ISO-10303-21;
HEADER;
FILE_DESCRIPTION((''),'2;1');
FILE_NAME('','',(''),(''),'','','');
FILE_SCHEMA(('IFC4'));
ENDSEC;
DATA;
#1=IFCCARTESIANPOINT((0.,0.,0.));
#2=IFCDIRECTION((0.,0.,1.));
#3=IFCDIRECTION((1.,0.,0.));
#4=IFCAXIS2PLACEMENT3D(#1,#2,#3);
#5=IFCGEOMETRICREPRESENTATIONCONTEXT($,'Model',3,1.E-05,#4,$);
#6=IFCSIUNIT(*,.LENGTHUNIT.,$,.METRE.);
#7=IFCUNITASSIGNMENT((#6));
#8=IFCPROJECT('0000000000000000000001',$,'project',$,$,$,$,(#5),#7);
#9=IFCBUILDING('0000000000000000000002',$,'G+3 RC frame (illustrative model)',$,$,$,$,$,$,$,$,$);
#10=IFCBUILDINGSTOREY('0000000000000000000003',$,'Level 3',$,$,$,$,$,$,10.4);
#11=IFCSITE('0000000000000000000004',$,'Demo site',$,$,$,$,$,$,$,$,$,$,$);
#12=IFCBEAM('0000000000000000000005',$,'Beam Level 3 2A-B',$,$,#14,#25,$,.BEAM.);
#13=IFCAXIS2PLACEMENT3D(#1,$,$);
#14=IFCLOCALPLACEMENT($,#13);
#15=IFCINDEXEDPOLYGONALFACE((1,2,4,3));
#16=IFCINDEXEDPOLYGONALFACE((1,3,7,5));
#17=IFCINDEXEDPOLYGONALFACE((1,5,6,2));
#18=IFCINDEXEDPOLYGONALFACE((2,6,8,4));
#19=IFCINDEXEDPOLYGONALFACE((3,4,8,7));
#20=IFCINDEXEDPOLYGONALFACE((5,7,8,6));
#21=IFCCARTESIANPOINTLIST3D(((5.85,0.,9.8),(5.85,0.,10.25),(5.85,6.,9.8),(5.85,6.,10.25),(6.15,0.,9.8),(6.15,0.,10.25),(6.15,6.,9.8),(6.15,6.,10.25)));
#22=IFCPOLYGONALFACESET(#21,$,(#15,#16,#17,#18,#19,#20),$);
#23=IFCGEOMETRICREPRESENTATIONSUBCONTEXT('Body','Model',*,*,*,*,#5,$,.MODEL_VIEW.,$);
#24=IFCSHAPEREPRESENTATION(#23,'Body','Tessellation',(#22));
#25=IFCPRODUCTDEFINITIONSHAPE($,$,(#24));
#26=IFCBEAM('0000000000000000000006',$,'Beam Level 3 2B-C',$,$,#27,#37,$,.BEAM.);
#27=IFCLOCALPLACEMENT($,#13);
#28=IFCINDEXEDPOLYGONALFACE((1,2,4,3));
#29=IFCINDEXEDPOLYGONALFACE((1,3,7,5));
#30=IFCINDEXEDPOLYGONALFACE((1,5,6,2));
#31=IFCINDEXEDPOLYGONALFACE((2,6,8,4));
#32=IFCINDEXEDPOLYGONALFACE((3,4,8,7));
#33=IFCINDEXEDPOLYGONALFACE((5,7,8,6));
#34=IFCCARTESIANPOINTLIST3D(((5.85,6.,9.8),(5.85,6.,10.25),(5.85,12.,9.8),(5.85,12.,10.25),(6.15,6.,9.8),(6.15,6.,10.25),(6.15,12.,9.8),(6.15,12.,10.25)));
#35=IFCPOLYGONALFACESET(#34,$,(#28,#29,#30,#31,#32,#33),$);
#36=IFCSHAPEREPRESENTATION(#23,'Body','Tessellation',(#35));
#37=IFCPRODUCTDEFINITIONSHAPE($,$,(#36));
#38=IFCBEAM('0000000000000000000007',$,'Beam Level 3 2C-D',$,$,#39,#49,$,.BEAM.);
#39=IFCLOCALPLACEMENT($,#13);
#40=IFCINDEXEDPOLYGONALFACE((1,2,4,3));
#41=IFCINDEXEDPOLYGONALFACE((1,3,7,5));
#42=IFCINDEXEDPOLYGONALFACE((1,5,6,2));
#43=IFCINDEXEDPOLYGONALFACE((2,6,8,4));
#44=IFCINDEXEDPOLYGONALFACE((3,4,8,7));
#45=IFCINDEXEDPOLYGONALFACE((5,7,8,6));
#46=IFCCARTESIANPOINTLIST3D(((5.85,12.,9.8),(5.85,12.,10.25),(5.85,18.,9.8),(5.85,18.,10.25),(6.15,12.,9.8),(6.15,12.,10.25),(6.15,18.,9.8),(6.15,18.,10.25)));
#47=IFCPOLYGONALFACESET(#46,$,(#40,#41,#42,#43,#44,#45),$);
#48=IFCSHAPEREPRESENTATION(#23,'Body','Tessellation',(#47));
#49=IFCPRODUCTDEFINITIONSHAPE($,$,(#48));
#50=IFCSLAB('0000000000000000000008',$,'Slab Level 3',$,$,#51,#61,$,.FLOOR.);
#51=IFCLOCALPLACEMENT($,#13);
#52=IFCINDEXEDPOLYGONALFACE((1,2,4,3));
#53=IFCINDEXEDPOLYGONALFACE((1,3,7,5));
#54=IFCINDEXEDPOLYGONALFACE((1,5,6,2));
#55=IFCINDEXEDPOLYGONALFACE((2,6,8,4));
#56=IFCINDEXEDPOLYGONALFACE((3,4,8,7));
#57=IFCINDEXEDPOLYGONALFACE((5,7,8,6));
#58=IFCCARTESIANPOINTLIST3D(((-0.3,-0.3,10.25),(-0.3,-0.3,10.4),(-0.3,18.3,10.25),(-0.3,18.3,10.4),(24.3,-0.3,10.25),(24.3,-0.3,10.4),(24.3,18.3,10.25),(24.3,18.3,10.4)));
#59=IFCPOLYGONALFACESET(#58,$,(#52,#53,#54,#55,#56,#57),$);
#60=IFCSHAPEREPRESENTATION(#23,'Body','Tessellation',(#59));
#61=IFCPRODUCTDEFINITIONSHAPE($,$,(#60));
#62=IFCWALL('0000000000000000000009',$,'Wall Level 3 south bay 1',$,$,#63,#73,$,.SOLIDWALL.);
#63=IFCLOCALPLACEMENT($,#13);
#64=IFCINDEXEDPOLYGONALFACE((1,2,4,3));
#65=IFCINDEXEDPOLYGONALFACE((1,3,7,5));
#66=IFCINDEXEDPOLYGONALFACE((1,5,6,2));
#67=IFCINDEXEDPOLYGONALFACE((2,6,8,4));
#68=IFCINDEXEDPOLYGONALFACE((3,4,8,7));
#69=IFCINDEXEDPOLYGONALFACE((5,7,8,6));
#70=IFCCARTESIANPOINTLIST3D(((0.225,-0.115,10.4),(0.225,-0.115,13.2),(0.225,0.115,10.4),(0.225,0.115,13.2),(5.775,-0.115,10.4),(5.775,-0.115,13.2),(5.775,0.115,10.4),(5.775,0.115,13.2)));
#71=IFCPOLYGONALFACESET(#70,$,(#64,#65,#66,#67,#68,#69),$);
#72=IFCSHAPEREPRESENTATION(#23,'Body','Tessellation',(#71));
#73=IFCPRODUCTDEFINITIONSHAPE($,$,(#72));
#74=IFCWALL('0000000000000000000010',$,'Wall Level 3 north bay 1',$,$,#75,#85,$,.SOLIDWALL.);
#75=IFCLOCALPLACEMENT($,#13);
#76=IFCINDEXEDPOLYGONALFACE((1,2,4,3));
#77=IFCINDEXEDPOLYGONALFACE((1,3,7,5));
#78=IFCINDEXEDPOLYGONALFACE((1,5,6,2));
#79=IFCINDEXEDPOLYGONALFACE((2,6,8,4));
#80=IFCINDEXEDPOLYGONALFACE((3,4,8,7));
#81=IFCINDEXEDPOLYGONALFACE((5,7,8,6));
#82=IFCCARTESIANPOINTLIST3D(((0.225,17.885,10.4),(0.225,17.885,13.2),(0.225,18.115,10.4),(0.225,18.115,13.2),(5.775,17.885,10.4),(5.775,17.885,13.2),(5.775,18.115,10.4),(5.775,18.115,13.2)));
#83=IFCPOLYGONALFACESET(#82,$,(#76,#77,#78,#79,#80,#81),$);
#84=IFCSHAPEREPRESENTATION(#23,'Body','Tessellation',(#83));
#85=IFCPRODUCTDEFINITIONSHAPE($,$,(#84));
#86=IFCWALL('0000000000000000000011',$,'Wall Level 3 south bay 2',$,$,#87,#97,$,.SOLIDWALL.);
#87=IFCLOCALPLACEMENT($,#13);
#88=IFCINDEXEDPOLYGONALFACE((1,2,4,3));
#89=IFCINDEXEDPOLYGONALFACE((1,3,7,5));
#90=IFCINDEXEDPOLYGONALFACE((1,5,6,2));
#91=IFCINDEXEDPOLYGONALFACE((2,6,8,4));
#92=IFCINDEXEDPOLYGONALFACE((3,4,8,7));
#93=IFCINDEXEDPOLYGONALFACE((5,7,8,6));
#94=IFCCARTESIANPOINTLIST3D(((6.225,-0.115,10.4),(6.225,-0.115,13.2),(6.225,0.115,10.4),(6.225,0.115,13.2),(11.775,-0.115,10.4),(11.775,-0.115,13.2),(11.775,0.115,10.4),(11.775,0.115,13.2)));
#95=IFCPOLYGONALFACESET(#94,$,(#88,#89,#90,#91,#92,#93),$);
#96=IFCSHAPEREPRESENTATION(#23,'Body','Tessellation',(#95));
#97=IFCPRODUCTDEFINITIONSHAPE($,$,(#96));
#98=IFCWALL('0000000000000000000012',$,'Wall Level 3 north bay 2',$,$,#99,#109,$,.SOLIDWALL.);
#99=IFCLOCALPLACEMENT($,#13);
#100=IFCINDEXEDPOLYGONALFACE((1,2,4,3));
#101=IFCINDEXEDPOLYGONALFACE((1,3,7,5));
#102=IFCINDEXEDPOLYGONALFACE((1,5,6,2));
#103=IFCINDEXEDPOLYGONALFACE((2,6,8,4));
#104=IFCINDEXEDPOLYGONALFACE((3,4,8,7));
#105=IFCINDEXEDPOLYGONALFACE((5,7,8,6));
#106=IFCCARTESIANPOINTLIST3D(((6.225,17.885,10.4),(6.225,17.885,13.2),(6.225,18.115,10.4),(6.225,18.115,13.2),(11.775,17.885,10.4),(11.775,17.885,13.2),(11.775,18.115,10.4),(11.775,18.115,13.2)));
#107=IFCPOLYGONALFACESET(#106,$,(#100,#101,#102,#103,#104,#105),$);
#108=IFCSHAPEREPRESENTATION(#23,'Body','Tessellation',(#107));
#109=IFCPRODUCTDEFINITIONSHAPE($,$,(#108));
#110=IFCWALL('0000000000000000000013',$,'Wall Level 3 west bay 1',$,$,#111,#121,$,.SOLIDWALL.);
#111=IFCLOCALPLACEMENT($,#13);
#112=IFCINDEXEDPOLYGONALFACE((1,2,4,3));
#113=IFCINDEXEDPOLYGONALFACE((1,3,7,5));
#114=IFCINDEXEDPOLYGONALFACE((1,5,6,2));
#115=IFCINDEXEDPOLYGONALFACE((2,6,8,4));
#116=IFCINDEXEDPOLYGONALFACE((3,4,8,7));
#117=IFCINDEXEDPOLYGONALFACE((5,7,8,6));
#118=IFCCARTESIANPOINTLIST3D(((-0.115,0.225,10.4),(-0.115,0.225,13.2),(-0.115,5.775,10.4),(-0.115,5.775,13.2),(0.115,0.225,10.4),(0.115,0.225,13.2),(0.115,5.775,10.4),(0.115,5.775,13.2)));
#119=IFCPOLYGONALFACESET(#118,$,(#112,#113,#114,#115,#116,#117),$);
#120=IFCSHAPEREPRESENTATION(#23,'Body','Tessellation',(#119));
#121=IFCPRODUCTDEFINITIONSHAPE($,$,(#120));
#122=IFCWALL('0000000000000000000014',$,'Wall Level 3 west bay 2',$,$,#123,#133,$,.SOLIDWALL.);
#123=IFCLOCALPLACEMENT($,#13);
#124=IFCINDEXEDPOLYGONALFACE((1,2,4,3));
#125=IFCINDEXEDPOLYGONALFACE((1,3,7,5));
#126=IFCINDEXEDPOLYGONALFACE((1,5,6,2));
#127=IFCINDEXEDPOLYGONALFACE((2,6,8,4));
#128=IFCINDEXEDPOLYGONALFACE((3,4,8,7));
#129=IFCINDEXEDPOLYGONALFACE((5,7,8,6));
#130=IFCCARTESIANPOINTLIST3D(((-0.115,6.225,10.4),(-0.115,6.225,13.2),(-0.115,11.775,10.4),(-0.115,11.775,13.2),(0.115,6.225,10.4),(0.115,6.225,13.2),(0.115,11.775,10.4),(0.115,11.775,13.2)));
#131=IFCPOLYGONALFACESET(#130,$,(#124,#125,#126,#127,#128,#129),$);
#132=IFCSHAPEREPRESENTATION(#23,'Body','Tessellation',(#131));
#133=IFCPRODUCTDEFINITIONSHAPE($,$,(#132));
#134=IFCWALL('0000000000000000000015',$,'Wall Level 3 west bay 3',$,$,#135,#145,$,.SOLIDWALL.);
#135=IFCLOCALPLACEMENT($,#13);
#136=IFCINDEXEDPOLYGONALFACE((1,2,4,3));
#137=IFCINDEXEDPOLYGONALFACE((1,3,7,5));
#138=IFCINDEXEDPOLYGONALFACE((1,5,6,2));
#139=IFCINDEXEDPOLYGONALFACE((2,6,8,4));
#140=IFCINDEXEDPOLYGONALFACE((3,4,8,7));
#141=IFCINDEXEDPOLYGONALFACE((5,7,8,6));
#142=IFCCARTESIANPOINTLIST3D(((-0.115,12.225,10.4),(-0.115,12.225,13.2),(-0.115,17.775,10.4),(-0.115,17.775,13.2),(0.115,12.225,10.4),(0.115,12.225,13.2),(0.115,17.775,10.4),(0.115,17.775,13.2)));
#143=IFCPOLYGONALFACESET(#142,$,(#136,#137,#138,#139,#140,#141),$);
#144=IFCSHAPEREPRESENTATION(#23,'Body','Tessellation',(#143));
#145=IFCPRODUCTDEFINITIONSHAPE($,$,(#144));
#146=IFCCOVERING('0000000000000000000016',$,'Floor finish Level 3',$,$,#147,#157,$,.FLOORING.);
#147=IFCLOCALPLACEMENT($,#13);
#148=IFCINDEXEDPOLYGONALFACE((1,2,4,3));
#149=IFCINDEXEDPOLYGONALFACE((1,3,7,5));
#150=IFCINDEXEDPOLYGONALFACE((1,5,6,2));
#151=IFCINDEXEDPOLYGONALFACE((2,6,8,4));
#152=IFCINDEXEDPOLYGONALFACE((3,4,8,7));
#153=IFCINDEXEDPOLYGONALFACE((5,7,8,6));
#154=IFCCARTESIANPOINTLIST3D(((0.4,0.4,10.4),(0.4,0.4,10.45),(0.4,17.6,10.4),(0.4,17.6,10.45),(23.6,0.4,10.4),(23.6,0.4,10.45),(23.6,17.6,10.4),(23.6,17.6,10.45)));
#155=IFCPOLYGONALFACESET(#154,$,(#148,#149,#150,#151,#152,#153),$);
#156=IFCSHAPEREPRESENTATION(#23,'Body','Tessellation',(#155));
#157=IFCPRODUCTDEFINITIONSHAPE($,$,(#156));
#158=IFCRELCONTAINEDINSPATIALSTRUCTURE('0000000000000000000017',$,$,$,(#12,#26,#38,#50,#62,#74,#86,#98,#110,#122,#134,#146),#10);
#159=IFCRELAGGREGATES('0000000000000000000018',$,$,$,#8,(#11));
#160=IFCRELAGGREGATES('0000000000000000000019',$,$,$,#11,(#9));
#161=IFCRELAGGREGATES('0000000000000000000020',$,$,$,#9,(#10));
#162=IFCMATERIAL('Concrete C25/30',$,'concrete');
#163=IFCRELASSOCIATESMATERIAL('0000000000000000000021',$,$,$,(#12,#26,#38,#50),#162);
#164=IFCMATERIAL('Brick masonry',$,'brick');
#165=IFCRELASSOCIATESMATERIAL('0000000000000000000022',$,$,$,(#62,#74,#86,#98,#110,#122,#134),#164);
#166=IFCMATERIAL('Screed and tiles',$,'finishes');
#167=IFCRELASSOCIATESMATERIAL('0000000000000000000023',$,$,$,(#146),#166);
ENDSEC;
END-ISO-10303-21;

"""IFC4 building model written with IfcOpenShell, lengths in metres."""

from ifc_helpers import new_model, si_unit, frame, frame_2d, origin, origin_with_axes, place, context, subcontext, project, spatial, rectangle, extrude, material, element, save


model = new_model("IFC4")

# Units and contexts
model_context = context("Model", 3, precision=1e-05, world=origin_with_axes())
body_context = subcontext(model_context, "Body", "Model", "MODEL_VIEW")
ifc_project = project(units=[si_unit("LENGTHUNIT", "METRE")], contexts=[model_context])

# Site, building, storey
site = spatial("IfcSite", under=ifc_project, Name="Demo site")
building = spatial("IfcBuilding", under=site, Name="G+3 RC frame (illustrative model)")
storey = spatial("IfcBuildingStorey", under=building, Name="Level 3", Elevation=10.4)

# Shared definitions
ifc_material_1 = material(Name="Concrete C25/30", Category="concrete")

# Beams
for number, where, z_axis, x_axis, name in (
    (1, (5.85, 0.0, 9.8), (0.0, 0.0, 1.0), (1.0, 0.0, 0.0), "Beam Level 3 2A-B"),
    (2, (5.85, 6.0, 9.8), (0.0, 0.0, 1.0), (1.0, 0.0, 0.0), "Beam Level 3 2B-C"),
    (3, (5.85, 12.0, 9.8), (0.0, 0.0, 1.0), (1.0, 0.0, 0.0), "Beam Level 3 2C-D"),
):
    element("IfcBeam", number, at=place(None, frame(where, z_axis=z_axis, x_axis=x_axis)), inside=storey, material=ifc_material_1, Name=name, PredefinedType="BEAM", context=body_context, shape_type="SweptSolid", body=[
        extrude(rectangle(XDim=0.3, YDim=6.0, at=frame_2d((0.15, 3.0))), origin(), (0.0, 0.0, 1.0), 0.45),
    ])

# Slab
slab_placement = place(None, frame((-0.3, -0.3, 10.25), z_axis=(0.0, 0.0, 1.0), x_axis=(1.0, 0.0, 0.0)))
element("IfcSlab", 4, at=slab_placement, inside=storey, material=ifc_material_1, Name="Slab Level 3", PredefinedType="FLOOR", context=body_context, shape_type="SweptSolid", body=[
    extrude(rectangle(XDim=24.6, YDim=18.6, at=frame_2d((12.3, 9.3))), origin(), (0.0, 0.0, 1.0), 0.15),
])

# Walls
ifc_material_2 = material(Name="Brick masonry", Category="brick")
for number, where, z_axis, x_axis, name in (
    (5, (0.225, -0.115, 10.4), (0.0, 0.0, 1.0), (1.0, 0.0, 0.0), "Wall Level 3 south bay 1"),
    (6, (0.225, 17.885, 10.4), (0.0, 0.0, 1.0), (1.0, 0.0, 0.0), "Wall Level 3 north bay 1"),
    (7, (6.225, -0.115, 10.4), (0.0, 0.0, 1.0), (1.0, 0.0, 0.0), "Wall Level 3 south bay 2"),
    (8, (6.225, 17.885, 10.4), (0.0, 0.0, 1.0), (1.0, 0.0, 0.0), "Wall Level 3 north bay 2"),
):
    element("IfcWall", number, at=place(None, frame(where, z_axis=z_axis, x_axis=x_axis)), inside=storey, material=ifc_material_2, Name=name, PredefinedType="SOLIDWALL", context=body_context, shape_type="SweptSolid", body=[
        extrude(rectangle(XDim=5.55, YDim=0.23, at=frame_2d((2.775, 0.115))), origin(), (0.0, 0.0, 1.0), 2.8),
    ])
for number, where, z_axis, x_axis, name in (
    (9, (-0.115, 0.225, 10.4), (0.0, 0.0, 1.0), (1.0, 0.0, 0.0), "Wall Level 3 west bay 1"),
    (10, (-0.115, 6.225, 10.4), (0.0, 0.0, 1.0), (1.0, 0.0, 0.0), "Wall Level 3 west bay 2"),
    (11, (-0.115, 12.225, 10.4), (0.0, 0.0, 1.0), (1.0, 0.0, 0.0), "Wall Level 3 west bay 3"),
):
    element("IfcWall", number, at=place(None, frame(where, z_axis=z_axis, x_axis=x_axis)), inside=storey, material=ifc_material_2, Name=name, PredefinedType="SOLIDWALL", context=body_context, shape_type="SweptSolid", body=[
        extrude(rectangle(XDim=0.23, YDim=5.55, at=frame_2d((0.115, 2.775))), origin(), (0.0, 0.0, 1.0), 2.8),
    ])

# Covering
ifc_material_3 = material(Name="Screed and tiles", Category="finishes")
covering_placement = place(None, frame((0.4, 0.4, 10.4), z_axis=(0.0, 0.0, 1.0), x_axis=(1.0, 0.0, 0.0)))
element("IfcCovering", 12, at=covering_placement, inside=storey, material=ifc_material_3, Name="Floor finish Level 3", PredefinedType="FLOORING", context=body_context, shape_type="SweptSolid", body=[
    extrude(rectangle(XDim=23.2, YDim=17.2, at=frame_2d((11.6, 8.6))), origin(), (0.0, 0.0, 1.0), 0.05),
])

save(model, "model.ifc")
